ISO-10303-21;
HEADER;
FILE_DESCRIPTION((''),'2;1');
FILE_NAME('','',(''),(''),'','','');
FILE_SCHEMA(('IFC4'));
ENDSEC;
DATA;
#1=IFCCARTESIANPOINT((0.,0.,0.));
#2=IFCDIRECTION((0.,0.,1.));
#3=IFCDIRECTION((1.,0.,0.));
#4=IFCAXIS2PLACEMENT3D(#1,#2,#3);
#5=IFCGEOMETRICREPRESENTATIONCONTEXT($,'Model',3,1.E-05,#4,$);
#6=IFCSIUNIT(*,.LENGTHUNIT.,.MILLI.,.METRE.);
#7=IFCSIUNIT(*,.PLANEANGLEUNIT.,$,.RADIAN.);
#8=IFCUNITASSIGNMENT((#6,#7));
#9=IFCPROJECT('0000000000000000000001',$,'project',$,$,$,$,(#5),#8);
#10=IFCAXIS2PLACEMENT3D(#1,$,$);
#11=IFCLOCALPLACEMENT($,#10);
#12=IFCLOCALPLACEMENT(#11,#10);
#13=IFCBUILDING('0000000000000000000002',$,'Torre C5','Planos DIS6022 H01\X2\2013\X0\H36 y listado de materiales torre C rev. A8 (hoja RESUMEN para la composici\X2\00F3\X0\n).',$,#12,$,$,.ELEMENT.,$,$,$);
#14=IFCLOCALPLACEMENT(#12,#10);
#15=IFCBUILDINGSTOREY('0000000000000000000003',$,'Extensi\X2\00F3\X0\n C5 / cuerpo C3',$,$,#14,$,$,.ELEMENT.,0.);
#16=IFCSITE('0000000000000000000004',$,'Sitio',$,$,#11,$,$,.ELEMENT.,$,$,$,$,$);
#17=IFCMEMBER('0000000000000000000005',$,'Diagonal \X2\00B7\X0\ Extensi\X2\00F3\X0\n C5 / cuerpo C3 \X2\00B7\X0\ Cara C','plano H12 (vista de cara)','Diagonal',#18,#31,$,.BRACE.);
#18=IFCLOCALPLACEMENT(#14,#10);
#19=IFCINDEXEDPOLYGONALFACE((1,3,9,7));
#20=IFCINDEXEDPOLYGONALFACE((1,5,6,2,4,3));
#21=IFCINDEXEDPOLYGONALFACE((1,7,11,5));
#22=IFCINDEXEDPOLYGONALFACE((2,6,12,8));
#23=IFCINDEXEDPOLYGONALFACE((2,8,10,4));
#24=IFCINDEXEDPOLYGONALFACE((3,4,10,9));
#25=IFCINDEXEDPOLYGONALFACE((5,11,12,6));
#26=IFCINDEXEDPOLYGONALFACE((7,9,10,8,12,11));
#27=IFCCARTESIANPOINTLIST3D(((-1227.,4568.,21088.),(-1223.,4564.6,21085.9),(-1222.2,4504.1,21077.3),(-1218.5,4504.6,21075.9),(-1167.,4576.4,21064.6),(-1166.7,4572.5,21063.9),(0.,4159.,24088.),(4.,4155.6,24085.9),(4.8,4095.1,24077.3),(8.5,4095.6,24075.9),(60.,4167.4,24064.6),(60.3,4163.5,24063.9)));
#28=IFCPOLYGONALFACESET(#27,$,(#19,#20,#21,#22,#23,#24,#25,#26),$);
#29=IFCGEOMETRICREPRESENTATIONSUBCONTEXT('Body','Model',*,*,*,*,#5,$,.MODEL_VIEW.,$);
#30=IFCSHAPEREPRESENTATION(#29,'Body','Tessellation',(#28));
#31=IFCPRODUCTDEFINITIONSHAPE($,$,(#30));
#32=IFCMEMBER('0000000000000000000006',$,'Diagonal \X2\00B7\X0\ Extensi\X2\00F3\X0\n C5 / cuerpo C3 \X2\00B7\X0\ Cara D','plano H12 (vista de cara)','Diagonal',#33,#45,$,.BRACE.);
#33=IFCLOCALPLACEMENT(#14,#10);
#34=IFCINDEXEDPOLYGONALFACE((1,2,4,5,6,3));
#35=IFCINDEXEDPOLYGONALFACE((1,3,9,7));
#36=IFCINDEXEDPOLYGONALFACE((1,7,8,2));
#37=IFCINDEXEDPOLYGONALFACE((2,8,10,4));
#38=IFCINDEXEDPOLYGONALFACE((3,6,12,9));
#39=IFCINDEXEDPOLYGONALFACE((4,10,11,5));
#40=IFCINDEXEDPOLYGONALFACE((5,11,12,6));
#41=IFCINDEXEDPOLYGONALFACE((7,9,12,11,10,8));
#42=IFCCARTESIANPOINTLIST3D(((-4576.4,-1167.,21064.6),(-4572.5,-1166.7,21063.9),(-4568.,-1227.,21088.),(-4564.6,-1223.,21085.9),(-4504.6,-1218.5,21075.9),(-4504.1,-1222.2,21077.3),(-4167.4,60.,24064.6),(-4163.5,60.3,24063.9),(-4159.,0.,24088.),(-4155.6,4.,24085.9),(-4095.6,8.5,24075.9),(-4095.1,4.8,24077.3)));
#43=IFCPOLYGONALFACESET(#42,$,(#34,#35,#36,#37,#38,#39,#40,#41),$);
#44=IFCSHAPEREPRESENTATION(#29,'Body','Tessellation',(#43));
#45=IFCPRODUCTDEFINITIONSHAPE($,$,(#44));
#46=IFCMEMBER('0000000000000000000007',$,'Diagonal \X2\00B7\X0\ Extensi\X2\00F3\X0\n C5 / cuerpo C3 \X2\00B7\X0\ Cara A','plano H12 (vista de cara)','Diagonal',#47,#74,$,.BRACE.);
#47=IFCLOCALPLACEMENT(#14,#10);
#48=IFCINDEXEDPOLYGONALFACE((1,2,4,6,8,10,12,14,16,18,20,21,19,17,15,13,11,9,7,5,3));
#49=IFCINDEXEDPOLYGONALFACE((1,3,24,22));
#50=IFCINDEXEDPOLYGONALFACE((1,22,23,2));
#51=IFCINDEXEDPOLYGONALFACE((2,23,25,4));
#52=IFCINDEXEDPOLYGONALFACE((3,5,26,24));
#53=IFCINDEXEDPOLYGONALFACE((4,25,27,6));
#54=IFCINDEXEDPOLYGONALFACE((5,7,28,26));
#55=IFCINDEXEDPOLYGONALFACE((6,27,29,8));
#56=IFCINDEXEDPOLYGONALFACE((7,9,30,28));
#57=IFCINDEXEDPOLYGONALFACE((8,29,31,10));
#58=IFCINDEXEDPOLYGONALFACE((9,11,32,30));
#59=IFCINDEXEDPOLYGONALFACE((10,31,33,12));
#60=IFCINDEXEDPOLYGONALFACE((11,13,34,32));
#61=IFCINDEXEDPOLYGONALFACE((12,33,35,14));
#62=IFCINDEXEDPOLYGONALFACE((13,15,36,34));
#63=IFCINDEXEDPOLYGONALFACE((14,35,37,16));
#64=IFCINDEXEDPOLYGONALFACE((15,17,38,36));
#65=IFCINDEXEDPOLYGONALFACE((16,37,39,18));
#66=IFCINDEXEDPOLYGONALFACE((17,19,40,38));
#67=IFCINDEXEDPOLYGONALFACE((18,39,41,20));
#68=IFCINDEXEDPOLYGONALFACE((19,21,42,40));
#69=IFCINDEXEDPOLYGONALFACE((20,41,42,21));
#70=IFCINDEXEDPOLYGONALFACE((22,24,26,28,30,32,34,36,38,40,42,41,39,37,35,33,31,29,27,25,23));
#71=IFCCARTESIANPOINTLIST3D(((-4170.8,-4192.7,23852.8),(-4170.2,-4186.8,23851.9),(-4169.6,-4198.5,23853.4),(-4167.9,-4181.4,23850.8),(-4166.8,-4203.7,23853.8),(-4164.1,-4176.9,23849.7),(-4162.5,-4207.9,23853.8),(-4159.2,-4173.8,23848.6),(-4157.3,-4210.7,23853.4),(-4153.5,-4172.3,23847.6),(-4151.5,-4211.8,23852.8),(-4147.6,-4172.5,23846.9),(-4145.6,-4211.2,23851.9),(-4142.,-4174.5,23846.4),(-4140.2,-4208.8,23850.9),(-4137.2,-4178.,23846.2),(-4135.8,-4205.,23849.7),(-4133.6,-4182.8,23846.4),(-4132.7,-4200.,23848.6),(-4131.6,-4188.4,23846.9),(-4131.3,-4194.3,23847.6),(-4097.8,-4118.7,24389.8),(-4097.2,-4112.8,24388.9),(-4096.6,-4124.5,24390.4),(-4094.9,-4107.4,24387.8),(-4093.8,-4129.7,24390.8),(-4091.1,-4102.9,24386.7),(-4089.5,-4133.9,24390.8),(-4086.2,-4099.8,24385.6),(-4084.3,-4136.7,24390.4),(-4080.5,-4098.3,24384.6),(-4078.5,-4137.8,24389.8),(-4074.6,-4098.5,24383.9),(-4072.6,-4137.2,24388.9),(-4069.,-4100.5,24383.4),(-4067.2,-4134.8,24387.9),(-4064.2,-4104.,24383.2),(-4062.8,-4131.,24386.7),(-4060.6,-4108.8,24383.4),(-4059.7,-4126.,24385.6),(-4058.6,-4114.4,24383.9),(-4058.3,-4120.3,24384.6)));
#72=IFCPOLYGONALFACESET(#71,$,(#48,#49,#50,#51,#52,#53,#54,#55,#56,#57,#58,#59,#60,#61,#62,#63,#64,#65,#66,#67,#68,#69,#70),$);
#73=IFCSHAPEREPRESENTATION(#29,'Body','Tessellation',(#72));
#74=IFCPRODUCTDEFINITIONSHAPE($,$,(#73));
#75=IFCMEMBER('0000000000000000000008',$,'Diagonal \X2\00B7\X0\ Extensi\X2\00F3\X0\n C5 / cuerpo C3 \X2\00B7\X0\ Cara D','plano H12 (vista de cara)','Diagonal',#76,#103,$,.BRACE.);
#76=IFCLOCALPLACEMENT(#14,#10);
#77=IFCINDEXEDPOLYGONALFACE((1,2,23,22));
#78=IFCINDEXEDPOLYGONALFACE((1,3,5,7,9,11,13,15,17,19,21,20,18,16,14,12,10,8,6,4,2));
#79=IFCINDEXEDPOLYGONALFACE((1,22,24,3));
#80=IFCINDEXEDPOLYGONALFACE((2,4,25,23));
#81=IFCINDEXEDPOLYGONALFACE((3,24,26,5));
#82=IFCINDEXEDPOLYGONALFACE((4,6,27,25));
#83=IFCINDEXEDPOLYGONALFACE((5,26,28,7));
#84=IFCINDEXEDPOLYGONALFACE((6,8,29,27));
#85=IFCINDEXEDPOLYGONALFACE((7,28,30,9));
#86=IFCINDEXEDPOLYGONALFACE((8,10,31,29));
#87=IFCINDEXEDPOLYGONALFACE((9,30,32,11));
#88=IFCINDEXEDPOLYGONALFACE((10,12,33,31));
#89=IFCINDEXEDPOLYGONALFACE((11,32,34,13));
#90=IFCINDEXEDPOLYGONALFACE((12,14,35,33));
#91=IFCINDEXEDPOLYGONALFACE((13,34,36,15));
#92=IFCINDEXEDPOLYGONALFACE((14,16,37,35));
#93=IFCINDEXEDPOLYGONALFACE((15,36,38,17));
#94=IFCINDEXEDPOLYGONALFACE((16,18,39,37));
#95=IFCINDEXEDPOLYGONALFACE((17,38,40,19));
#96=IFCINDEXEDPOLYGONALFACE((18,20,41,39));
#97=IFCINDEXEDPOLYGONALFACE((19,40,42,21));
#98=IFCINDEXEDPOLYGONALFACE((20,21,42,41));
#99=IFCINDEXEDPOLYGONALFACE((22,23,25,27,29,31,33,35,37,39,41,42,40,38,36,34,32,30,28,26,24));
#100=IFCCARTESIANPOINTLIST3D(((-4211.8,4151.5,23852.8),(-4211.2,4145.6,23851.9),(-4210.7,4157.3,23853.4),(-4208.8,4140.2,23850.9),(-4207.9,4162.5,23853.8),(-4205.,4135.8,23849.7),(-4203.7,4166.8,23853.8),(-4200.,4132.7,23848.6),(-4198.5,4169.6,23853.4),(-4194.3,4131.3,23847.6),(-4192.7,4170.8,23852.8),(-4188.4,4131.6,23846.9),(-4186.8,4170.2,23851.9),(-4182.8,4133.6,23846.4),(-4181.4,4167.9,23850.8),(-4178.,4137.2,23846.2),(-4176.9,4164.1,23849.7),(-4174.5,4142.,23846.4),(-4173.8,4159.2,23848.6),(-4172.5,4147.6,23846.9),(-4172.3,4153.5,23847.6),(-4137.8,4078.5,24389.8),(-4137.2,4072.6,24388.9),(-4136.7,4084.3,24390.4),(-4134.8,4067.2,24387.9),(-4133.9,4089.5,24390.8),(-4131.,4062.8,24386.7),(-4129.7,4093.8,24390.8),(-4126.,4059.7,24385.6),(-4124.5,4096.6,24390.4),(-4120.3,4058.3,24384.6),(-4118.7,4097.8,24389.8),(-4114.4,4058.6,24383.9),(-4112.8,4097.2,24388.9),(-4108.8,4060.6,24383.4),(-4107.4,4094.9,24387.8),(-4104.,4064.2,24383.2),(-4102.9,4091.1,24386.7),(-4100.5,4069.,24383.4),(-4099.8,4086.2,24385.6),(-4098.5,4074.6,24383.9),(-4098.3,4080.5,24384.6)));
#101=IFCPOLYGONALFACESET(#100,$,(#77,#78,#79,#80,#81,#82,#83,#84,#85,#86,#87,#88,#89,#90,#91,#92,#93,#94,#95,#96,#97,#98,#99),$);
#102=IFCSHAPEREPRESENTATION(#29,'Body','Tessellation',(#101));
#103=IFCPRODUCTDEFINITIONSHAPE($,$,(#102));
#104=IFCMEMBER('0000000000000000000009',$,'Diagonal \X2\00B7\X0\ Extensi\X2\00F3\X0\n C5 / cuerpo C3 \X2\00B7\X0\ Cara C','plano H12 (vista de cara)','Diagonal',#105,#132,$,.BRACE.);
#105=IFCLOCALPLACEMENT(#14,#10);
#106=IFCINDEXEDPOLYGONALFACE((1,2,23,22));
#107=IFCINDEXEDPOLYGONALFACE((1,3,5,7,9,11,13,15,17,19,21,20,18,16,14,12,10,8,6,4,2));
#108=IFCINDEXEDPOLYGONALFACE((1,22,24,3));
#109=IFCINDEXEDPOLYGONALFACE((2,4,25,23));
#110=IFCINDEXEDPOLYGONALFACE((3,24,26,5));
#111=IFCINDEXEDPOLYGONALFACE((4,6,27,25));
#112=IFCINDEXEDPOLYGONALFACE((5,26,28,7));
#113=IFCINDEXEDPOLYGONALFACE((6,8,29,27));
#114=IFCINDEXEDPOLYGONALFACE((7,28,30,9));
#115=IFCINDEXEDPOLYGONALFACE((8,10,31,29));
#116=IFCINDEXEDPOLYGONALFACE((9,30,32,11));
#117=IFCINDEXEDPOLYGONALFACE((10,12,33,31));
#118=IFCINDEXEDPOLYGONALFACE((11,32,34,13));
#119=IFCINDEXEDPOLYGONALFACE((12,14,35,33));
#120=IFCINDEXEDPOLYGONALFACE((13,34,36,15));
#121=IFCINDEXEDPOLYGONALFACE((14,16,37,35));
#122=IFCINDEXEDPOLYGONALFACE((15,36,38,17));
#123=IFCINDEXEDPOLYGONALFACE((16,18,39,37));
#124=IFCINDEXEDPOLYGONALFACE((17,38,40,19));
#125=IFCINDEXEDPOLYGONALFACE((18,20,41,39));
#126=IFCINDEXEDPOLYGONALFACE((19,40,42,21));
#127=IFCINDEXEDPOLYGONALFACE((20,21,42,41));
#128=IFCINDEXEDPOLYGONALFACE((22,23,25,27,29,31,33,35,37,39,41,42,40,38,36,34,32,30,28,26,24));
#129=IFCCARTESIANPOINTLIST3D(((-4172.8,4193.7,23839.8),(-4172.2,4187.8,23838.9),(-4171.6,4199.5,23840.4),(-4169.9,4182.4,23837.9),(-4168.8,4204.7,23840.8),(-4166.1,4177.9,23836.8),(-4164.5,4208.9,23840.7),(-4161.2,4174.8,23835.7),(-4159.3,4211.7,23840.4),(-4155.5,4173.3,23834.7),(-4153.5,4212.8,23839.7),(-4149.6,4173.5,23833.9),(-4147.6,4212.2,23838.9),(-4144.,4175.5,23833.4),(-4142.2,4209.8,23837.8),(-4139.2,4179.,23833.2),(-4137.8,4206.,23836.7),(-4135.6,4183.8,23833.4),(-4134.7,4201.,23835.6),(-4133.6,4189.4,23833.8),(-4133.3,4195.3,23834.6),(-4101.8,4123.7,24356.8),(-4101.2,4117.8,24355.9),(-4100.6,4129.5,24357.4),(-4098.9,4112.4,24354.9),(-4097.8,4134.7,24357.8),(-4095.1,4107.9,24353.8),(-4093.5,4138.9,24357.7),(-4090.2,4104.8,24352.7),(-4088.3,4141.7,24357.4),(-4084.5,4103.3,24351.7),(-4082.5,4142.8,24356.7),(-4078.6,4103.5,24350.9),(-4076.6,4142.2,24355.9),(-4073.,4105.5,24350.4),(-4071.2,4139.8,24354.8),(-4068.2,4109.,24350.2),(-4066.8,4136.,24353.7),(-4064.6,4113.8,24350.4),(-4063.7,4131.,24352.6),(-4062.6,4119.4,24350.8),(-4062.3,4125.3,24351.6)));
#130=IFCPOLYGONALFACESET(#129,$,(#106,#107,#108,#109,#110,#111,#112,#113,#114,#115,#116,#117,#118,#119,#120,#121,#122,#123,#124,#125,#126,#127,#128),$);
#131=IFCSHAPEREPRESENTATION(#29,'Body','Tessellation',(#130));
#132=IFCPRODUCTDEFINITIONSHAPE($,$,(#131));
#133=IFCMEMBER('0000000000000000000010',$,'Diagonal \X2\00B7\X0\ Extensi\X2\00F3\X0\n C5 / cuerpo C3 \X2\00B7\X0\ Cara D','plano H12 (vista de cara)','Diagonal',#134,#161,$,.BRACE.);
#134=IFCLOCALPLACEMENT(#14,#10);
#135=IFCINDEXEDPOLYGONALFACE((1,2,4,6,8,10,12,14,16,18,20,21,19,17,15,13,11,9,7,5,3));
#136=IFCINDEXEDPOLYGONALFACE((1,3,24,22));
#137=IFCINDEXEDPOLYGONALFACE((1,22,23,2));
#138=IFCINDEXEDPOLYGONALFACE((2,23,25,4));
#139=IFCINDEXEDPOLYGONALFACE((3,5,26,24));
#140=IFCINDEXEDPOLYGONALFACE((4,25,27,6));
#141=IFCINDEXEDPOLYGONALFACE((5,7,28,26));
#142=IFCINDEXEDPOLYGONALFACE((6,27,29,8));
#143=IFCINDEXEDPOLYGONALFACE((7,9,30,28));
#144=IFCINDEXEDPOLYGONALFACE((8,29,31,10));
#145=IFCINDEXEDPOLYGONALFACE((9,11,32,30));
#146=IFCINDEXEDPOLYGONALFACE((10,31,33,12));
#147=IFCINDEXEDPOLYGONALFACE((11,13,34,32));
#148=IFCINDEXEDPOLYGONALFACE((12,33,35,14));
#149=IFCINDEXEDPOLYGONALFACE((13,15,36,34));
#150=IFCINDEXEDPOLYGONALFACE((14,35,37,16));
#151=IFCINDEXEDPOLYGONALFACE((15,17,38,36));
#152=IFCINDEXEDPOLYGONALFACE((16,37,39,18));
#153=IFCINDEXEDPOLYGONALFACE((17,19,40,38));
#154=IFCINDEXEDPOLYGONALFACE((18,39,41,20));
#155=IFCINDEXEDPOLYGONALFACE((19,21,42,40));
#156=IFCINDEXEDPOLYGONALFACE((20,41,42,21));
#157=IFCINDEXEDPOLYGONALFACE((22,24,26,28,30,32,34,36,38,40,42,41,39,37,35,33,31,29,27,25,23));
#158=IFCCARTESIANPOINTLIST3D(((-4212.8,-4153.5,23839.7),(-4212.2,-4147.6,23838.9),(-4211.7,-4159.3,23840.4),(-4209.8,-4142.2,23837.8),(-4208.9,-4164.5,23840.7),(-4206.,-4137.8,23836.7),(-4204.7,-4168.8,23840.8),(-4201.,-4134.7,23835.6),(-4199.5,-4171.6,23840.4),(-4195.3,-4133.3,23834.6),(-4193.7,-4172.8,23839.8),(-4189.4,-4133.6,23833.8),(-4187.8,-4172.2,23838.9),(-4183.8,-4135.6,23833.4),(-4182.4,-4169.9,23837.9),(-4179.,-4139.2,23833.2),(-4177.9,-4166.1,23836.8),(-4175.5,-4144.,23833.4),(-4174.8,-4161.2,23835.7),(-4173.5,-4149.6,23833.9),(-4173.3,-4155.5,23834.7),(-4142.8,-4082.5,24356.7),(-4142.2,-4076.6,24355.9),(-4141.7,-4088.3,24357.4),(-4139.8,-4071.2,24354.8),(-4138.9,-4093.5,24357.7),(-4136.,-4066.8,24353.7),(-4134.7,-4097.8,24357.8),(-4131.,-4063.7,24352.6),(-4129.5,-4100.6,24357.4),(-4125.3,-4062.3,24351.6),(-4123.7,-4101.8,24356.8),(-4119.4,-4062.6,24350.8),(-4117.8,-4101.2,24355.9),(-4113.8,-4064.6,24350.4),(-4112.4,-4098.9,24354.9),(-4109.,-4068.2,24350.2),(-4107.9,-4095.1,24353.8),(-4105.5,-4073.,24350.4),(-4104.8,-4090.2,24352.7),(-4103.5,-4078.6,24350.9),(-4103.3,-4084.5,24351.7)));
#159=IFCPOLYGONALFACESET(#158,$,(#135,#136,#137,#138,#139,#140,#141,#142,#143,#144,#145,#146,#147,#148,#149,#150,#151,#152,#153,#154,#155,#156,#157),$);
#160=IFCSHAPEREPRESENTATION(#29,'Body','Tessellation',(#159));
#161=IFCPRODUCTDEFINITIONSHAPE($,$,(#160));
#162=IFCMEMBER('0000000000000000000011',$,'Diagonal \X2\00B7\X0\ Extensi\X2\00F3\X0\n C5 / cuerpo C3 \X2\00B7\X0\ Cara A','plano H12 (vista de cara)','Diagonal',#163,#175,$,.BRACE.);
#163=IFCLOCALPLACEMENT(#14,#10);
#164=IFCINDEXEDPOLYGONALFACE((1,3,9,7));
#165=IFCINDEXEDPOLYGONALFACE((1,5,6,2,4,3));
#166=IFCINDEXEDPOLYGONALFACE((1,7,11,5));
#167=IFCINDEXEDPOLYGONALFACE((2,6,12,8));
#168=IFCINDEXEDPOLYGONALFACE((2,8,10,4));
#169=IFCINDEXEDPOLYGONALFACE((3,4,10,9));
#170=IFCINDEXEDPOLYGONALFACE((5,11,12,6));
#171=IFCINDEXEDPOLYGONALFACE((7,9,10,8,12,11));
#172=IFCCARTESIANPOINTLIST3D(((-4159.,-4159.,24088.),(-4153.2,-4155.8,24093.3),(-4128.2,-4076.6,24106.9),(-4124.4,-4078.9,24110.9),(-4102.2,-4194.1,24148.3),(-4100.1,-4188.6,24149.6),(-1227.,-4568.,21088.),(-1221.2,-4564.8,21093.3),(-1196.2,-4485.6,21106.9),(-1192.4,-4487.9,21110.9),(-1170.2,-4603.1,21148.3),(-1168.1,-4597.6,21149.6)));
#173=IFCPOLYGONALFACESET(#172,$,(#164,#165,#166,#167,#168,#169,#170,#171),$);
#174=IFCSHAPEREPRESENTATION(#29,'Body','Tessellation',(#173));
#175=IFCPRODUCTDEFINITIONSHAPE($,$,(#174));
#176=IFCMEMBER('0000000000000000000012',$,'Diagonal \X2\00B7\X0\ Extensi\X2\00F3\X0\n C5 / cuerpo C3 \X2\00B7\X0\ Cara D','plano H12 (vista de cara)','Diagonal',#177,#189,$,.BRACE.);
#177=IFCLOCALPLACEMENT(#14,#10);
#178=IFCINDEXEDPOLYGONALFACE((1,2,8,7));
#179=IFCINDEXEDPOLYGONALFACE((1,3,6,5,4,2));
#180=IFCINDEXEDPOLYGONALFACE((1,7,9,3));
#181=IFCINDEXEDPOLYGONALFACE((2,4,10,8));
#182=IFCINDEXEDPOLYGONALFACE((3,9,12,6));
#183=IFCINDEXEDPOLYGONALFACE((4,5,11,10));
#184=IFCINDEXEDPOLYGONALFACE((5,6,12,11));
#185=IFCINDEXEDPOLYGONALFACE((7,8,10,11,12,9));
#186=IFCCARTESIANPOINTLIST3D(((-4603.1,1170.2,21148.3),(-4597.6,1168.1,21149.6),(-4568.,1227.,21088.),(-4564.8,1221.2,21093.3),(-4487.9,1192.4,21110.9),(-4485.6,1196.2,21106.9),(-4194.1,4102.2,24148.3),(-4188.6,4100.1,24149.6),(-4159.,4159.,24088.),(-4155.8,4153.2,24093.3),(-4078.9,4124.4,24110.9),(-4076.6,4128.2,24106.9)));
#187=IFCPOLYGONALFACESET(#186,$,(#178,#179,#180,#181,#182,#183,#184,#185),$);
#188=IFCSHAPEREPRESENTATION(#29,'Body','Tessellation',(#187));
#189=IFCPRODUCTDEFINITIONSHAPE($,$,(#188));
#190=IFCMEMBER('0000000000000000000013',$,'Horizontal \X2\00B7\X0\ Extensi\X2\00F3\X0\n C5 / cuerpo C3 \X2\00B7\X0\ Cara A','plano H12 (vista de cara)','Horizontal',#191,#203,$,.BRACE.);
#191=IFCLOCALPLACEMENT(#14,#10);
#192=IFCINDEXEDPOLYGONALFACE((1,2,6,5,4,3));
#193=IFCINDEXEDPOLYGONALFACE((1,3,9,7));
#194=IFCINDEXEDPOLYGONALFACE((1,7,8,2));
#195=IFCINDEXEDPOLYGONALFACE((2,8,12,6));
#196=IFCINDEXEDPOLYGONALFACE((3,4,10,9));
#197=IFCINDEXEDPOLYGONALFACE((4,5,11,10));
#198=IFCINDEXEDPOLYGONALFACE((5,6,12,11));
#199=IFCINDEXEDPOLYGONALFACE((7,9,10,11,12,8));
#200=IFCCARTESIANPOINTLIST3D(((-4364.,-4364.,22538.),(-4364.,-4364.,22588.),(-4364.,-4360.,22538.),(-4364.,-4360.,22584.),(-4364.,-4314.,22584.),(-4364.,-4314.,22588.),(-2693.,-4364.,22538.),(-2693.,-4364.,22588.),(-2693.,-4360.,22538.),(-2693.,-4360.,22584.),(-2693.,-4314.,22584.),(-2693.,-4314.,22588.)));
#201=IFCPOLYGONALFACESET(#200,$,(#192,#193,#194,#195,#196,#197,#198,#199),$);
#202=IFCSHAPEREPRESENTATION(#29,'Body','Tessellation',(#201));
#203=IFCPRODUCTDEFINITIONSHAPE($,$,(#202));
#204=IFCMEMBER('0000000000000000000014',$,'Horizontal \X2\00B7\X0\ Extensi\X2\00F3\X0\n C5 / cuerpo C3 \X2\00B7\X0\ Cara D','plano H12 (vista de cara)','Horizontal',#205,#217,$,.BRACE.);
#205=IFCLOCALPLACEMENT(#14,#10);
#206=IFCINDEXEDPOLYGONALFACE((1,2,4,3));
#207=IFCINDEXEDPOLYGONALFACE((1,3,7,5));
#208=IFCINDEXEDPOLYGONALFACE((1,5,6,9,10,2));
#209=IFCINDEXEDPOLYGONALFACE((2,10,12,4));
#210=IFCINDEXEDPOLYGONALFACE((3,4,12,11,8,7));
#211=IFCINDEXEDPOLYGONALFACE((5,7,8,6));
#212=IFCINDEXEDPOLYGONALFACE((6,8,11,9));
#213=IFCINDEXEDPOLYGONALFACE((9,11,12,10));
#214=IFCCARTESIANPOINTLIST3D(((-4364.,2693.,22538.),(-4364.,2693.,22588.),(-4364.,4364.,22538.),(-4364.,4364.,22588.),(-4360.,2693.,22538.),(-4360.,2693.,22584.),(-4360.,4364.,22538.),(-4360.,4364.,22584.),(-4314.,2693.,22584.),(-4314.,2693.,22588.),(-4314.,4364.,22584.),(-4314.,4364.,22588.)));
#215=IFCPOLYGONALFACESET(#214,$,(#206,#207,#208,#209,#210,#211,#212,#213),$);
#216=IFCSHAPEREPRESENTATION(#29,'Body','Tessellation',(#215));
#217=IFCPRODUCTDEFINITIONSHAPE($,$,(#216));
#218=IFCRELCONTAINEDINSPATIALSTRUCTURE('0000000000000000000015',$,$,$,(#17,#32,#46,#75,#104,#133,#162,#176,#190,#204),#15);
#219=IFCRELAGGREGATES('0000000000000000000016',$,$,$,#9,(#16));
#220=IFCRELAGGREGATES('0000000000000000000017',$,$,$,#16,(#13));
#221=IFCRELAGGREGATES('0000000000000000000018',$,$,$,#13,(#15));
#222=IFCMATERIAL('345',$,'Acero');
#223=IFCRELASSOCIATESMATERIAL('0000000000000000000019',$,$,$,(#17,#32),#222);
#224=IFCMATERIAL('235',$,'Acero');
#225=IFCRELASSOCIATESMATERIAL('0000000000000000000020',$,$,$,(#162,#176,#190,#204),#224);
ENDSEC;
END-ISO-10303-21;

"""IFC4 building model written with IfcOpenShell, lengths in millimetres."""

from ifc_helpers import new_model, si_unit, frame, frame_2d, origin, origin_with_axes, place, context, subcontext, project, spatial, circle, l_section, extrude, material, element, save


model = new_model("IFC4")

# Units and contexts
model_context = context("Model", 3, precision=1e-05, world=origin_with_axes())
body_context = subcontext(model_context, "Body", "Model", "MODEL_VIEW")
ifc_project = project(units=[si_unit("LENGTHUNIT", "METRE", prefix="MILLI"), si_unit("PLANEANGLEUNIT", "RADIAN")], contexts=[model_context])

# Site, building, storey
site_placement = place(None, origin())
site = spatial("IfcSite", under=ifc_project, at=site_placement, Name="Sitio", CompositionType="ELEMENT")
building_placement = place(site_placement, origin())
building = spatial("IfcBuilding", under=site, at=building_placement, Name="Torre C5", Description="Planos DIS6022 H01–H36 y listado de materiales torre C rev. A8 (hoja RESUMEN para la composición).", CompositionType="ELEMENT")
storey_placement = place(building_placement, origin())
storey = spatial("IfcBuildingStorey", under=building, at=storey_placement, Name="Extensión C5 / cuerpo C3", CompositionType="ELEMENT", Elevation=0.0)

# Members
ifc_material_1 = material(Name="235", Category="Acero")
ifc_material_2 = material(Name="345", Category="Acero")
for number, where, z_axis, x_axis, name in (
    (1, (-1227.0, 4568.0, 21088.0), (0.375582, -0.125194, 0.918294), (0.074188, -0.983593, -0.164439), "Diagonal · Extensión C5 / cuerpo C3 · Cara C"),
    (2, (-4568.0, -1227.0, 21088.0), (0.125194, 0.375582, 0.918294), (0.983593, 0.074188, -0.164439), "Diagonal · Extensión C5 / cuerpo C3 · Cara D"),
):
    element("IfcMember", number, at=place(storey_placement, frame(where, z_axis=z_axis, x_axis=x_axis)), inside=storey, material=ifc_material_2, Name=name, Description="plano H12 (vista de cara)", ObjectType="Diagonal", PredefinedType="BRACE", context=body_context, shape_type="SweptSolid", body=[
        extrude(l_section(Depth=65.0, Width=65.0, Thickness=4.0, at=frame_2d((32.5, 32.5))), None, (0.0, 0.0, 1.0), 3266.9),
    ])
for number, where, z_axis, x_axis, name in (
    (3, (-4078.0, -4118.0, 24387.0), (-0.133463, -0.135291, -0.981776), (0.690862, 0.697563, -0.190042), "Diagonal · Extensión C5 / cuerpo C3 · Cara A"),
    (4, (-4118.0, 4078.0, 24387.0), (-0.135291, 0.133463, -0.981776), (0.697563, -0.690862, -0.190042), "Diagonal · Extensión C5 / cuerpo C3 · Cara D"),
):
    element("IfcMember", number, at=place(storey_placement, frame(where, z_axis=z_axis, x_axis=x_axis)), inside=storey, Name=name, Description="plano H12 (vista de cara)", ObjectType="Diagonal", PredefinedType="BRACE", context=body_context, shape_type="SweptSolid", body=[
        extrude(circle(Radius=20.0), None, (0.0, 0.0, 1.0), 547.0),
    ])
for number, where, z_axis, x_axis, name in (
    (5, (-4082.0, 4123.0, 24354.0), (-0.134846, 0.132947, -0.981907), (0.690598, -0.698013, -0.189349), "Diagonal · Extensión C5 / cuerpo C3 · Cara C"),
    (6, (-4123.0, -4082.0, 24354.0), (-0.132947, -0.134846, -0.981907), (0.698013, 0.690598, -0.189349), "Diagonal · Extensión C5 / cuerpo C3 · Cara D"),
):
    element("IfcMember", number, at=place(storey_placement, frame(where, z_axis=z_axis, x_axis=x_axis)), inside=storey, Name=name, Description="plano H12 (vista de cara)", ObjectType="Diagonal", PredefinedType="BRACE", context=body_context, shape_type="SweptSolid", body=[
        extrude(circle(Radius=20.0), None, (0.0, 0.0, 1.0), 526.5),
    ])
for number, where, z_axis, x_axis, name in (
    (7, (-4159.0, -4159.0, 24088.0), (0.695656, -0.097041, -0.71179), (0.342458, 0.9158, 0.209842), "Diagonal · Extensión C5 / cuerpo C3 · Cara A"),
    (8, (-4159.0, 4159.0, 24088.0), (-0.097041, -0.695656, -0.71179), (0.9158, -0.342458, 0.209842), "Diagonal · Extensión C5 / cuerpo C3 · Cara D"),
):
    element("IfcMember", number, at=place(storey_placement, frame(where, z_axis=z_axis, x_axis=x_axis)), inside=storey, material=ifc_material_1, Name=name, Description="plano H12 (vista de cara)", ObjectType="Diagonal", PredefinedType="BRACE", context=body_context, shape_type="SweptSolid", body=[
        extrude(l_section(Depth=90.0, Width=90.0, Thickness=6.0, at=frame_2d((45.0, 45.0))), None, (0.0, 0.0, 1.0), 4214.7),
    ])
for number, where, z_axis, x_axis, name in (
    (9, (-2693.0, -4364.0, 22588.0), (-1.0, 0.0, 0.0), (0.0, 1.0, 0.0), "Horizontal · Extensión C5 / cuerpo C3 · Cara A"),
    (10, (-4364.0, 2693.0, 22588.0), (0.0, 1.0, 0.0), (1.0, 0.0, 0.0), "Horizontal · Extensión C5 / cuerpo C3 · Cara D"),
):
    element("IfcMember", number, at=place(storey_placement, frame(where, z_axis=z_axis, x_axis=x_axis)), inside=storey, material=ifc_material_1, Name=name, Description="plano H12 (vista de cara)", ObjectType="Horizontal", PredefinedType="BRACE", context=body_context, shape_type="SweptSolid", body=[
        extrude(l_section(Depth=50.0, Width=50.0, Thickness=4.0, at=frame_2d((25.0, 25.0))), None, (0.0, 0.0, 1.0), 1671.0),
    ])

save(model, "model.ifc")
